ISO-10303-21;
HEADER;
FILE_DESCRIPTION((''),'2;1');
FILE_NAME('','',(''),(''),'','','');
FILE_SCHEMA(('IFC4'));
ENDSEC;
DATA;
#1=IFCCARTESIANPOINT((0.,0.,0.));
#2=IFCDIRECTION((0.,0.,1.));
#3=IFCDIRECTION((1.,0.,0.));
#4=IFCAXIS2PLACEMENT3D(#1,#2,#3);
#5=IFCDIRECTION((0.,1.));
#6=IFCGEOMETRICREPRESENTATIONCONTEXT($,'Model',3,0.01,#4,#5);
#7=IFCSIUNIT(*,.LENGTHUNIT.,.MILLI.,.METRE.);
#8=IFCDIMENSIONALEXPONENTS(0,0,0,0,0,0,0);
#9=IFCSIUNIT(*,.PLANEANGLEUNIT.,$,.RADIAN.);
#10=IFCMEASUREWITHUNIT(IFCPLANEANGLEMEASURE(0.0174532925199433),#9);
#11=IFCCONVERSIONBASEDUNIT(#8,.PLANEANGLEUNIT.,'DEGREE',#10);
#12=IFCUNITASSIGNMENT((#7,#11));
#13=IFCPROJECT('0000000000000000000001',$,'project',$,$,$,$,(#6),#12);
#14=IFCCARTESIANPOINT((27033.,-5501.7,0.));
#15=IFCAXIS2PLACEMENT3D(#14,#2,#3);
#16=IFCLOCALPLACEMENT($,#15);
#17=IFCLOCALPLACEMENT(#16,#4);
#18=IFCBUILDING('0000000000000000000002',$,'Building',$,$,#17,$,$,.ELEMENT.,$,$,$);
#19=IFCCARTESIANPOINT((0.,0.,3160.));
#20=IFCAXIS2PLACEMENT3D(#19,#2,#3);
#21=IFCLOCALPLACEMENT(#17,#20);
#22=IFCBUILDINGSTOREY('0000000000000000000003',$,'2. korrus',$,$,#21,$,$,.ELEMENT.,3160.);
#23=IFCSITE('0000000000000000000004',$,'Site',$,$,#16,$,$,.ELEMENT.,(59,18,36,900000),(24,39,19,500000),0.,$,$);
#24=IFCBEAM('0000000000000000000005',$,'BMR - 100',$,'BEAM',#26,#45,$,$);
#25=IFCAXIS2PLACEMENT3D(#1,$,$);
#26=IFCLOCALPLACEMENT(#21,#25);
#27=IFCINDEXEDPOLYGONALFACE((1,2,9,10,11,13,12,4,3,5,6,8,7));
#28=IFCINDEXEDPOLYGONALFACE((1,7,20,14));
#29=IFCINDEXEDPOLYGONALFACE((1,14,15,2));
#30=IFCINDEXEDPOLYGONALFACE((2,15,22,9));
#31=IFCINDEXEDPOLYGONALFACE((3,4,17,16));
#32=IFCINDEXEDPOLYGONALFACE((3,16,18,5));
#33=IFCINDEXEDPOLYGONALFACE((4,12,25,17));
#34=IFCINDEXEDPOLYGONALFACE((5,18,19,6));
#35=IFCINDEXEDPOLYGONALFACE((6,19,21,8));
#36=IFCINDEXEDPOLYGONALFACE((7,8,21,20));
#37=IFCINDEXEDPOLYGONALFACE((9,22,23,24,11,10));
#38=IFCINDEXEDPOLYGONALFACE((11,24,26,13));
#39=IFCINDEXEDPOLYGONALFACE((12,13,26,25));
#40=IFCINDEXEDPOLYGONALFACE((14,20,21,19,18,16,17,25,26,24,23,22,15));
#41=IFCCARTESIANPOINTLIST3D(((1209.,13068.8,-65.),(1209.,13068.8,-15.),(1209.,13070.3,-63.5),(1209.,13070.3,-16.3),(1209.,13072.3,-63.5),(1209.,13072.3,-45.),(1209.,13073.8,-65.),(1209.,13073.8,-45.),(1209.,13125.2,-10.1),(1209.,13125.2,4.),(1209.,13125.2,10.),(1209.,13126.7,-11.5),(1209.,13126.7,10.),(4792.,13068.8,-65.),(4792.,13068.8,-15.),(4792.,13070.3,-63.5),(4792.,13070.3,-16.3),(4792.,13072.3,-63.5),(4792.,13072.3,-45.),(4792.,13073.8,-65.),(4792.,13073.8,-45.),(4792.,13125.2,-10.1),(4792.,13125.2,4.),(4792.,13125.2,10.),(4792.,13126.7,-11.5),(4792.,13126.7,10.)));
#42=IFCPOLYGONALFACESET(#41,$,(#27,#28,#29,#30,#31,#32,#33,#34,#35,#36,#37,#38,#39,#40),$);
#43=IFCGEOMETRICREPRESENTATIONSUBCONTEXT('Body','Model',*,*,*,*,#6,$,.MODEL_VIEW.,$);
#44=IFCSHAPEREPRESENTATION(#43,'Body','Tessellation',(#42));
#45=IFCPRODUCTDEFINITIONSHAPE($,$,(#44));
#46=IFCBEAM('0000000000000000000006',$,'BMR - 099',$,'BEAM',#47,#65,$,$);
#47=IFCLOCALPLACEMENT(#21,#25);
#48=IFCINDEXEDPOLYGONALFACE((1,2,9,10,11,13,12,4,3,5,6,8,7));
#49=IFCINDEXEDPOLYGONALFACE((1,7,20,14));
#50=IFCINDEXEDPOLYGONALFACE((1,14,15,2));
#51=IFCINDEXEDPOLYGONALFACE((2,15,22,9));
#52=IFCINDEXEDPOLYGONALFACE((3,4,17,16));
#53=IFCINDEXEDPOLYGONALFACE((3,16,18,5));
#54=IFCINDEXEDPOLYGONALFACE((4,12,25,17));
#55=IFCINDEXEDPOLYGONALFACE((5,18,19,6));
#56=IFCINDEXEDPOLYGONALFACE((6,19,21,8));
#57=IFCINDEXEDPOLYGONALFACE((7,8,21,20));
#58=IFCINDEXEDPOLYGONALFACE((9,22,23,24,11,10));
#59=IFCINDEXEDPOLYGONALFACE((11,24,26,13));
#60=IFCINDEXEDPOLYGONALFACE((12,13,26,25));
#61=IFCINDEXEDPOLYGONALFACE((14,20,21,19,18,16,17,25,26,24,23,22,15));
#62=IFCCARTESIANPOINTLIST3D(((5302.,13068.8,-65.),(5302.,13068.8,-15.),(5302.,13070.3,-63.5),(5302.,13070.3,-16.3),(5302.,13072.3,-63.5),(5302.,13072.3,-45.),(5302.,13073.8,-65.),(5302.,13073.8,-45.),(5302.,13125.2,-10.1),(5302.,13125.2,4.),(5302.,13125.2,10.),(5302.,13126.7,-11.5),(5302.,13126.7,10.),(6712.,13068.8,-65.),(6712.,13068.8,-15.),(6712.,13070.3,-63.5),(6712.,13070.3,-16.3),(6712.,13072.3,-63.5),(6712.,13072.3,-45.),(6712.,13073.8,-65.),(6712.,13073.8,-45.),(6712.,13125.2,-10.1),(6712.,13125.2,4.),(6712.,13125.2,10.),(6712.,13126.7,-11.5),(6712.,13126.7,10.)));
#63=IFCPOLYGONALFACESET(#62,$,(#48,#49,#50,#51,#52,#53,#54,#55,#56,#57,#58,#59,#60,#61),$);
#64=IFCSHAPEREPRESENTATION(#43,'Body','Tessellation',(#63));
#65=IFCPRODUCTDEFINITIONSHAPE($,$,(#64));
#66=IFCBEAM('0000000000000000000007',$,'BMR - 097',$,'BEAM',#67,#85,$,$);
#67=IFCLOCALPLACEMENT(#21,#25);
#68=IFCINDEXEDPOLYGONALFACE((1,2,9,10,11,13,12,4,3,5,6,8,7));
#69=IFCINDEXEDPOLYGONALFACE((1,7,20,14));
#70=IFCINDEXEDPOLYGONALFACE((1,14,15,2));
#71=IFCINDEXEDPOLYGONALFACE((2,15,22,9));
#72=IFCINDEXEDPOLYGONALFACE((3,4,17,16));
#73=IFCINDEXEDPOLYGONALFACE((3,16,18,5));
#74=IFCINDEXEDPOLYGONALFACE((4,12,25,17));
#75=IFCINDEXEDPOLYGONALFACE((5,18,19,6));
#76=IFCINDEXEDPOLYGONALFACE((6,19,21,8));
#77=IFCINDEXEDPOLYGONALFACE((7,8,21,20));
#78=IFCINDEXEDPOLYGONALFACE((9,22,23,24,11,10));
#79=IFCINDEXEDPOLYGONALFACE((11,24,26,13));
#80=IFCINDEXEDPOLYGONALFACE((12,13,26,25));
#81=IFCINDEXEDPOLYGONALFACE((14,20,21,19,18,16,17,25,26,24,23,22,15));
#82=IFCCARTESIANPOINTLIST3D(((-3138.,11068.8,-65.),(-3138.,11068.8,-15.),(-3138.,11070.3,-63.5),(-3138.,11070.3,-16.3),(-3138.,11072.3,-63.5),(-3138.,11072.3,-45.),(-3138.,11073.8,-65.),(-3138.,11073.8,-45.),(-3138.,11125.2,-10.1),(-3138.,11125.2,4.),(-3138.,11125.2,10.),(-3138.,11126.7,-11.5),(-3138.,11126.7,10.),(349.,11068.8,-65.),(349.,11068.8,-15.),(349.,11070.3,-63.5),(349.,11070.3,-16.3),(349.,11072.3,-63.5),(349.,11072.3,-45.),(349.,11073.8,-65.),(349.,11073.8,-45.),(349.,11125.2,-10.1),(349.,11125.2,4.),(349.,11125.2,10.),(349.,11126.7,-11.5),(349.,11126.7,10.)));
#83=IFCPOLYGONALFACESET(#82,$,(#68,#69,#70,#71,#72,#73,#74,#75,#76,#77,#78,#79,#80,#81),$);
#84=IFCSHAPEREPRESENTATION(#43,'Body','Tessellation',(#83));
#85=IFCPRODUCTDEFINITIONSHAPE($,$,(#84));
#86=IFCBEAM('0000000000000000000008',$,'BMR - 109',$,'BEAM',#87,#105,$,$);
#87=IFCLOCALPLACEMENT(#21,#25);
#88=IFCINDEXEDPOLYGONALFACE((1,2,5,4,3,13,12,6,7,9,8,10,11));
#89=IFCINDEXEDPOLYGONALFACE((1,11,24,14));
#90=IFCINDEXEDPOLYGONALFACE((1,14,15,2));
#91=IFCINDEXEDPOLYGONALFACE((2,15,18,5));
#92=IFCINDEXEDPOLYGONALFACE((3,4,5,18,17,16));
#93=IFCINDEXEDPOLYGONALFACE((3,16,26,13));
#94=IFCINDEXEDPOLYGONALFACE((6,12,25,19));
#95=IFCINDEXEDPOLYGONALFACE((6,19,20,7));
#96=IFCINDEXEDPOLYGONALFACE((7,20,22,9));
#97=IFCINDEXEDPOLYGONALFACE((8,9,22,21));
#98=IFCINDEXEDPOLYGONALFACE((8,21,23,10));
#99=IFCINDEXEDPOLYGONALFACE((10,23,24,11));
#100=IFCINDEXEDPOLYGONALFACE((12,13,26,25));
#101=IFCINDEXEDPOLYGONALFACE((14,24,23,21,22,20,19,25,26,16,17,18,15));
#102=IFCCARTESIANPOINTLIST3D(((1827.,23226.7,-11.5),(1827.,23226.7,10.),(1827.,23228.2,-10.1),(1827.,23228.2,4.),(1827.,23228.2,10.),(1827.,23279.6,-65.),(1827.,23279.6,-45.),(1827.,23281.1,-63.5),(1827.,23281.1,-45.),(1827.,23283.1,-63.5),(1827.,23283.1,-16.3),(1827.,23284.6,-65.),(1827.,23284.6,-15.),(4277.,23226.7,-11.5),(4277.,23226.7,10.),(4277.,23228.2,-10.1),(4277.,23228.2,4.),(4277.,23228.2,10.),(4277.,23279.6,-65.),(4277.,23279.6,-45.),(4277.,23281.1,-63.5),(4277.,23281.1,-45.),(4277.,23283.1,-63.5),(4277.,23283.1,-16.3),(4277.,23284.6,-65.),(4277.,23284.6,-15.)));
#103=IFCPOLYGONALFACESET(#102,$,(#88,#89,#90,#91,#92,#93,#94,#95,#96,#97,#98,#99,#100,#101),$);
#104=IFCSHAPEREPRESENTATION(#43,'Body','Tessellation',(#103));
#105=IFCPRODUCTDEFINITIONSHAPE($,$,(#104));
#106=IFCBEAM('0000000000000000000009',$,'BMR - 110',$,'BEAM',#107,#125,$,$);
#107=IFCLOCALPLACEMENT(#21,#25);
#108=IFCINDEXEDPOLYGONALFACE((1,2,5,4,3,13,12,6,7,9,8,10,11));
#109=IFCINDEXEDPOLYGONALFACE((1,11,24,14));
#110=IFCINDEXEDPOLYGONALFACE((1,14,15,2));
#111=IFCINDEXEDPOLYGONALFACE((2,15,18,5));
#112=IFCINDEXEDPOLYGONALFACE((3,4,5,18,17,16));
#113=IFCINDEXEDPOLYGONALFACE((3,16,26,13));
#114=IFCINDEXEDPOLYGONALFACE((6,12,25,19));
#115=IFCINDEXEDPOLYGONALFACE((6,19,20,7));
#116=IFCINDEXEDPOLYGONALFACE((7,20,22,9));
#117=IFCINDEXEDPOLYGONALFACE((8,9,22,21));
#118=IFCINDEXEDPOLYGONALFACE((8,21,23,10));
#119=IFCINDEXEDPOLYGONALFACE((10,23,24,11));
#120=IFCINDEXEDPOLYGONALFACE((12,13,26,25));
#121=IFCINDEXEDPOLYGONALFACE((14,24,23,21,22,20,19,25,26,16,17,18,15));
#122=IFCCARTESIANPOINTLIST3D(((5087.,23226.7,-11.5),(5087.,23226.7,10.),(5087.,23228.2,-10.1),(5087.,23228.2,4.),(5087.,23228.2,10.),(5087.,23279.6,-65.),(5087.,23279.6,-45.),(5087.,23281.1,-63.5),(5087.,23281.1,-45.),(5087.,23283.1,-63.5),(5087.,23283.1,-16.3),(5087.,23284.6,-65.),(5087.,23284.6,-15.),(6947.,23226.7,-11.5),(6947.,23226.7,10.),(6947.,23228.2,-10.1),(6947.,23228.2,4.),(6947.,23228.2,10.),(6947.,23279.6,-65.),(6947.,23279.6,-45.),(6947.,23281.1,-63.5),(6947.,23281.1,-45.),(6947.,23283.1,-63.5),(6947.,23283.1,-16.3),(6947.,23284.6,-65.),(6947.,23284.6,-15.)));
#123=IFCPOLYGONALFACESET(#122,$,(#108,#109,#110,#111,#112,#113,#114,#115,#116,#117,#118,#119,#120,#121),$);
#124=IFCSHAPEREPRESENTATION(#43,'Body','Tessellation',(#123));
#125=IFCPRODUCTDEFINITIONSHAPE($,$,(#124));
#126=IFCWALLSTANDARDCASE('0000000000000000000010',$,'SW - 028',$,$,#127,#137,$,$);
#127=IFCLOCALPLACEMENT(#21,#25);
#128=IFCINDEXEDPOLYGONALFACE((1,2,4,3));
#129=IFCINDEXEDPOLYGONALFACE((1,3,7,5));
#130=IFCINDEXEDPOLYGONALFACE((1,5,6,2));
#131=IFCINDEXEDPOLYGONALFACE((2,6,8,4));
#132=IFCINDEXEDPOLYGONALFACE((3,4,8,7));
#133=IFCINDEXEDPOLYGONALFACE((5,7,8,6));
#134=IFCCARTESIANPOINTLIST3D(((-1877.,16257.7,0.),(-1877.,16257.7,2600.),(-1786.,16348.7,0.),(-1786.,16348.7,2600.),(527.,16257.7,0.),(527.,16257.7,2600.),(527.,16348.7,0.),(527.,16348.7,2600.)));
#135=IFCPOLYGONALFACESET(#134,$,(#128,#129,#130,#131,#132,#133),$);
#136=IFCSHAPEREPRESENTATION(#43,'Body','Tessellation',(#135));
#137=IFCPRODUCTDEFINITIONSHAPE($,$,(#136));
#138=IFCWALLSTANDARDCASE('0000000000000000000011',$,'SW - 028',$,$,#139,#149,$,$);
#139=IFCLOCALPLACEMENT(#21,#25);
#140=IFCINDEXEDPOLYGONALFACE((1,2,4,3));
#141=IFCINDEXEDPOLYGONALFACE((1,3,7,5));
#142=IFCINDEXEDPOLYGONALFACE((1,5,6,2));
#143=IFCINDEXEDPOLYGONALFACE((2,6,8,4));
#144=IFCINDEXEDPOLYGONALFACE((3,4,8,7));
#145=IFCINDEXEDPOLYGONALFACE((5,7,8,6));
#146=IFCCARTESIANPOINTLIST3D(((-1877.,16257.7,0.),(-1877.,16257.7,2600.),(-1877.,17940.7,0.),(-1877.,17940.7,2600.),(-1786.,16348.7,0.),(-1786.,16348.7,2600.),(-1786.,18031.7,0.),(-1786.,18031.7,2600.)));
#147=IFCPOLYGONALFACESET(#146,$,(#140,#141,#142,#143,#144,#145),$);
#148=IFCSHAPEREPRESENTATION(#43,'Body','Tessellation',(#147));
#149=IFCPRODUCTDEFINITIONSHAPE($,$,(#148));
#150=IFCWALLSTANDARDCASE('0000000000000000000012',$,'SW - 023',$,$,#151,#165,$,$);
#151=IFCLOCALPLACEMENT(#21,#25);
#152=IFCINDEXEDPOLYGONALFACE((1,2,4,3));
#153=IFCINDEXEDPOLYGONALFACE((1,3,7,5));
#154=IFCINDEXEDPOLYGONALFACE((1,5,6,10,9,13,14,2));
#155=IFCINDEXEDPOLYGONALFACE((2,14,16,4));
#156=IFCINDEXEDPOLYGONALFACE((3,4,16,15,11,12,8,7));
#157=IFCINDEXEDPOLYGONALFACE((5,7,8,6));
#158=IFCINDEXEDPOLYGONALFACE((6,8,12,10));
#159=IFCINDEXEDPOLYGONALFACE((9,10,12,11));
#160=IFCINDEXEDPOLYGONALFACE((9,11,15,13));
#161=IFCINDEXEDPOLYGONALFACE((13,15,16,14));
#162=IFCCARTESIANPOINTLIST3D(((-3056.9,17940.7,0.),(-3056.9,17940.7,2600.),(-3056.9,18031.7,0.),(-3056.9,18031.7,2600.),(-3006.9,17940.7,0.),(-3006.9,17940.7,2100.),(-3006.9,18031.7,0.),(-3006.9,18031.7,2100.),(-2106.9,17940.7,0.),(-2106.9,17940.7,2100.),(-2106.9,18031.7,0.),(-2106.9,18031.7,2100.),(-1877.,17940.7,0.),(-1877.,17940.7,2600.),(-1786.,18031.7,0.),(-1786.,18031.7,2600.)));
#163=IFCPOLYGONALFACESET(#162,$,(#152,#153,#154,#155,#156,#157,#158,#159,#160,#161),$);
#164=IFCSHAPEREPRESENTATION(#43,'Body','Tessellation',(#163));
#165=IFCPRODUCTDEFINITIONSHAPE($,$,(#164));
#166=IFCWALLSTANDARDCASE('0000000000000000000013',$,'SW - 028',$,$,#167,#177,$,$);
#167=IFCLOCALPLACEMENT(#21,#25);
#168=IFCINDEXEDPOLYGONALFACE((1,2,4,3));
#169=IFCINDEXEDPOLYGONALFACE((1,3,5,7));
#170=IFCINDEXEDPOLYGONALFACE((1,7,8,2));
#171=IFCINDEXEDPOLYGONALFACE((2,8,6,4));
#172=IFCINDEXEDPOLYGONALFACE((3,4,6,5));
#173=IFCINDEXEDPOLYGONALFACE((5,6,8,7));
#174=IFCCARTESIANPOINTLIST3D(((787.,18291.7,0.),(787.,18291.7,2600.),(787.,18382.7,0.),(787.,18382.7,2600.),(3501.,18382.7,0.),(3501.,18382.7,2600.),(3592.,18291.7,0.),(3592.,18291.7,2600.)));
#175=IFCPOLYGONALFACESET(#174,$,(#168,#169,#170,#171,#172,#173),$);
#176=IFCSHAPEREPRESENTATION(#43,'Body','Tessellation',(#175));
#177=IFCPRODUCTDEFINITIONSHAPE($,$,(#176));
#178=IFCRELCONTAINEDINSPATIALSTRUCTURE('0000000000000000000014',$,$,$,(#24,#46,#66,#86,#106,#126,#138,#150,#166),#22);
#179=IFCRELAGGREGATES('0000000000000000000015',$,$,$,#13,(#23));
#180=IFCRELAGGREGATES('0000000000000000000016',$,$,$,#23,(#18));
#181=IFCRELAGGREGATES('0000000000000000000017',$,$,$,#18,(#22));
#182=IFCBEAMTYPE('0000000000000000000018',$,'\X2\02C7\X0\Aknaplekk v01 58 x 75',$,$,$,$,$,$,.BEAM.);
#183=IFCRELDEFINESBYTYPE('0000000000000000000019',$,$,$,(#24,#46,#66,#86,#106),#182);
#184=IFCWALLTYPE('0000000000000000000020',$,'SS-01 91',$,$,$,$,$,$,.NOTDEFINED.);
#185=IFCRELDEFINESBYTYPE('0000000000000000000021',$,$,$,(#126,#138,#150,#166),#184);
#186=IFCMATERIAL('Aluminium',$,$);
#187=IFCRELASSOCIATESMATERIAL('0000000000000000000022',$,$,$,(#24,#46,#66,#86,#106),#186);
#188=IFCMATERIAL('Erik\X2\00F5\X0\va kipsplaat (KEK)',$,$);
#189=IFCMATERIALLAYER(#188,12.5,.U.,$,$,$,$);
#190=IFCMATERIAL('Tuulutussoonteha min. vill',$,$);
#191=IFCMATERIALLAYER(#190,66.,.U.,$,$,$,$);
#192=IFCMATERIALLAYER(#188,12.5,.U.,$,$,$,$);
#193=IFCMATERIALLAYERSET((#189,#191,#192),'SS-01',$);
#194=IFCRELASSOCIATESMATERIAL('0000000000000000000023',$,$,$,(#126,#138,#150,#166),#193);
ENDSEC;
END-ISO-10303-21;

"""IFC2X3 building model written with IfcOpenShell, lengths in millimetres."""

from ifc_helpers import new_model, entity, si_unit, converted_unit, direction, frame, origin_with_axes, origin_2d_with_axis, place, context, subcontext, project, spatial, polyline, rectangle, outline, extrude, material, layer, layer_set, layer_usage, type_object, element, save


model = new_model("IFC2X3")

# Units and contexts
model_context = context("Model", 3, precision=0.01, world=origin_with_axes(), true_north=direction((0.0, 1.0)))
body_context = subcontext(model_context, "Body", "Model", "MODEL_VIEW")
ifc_project = project(units=[si_unit("LENGTHUNIT", "METRE", prefix="MILLI"), converted_unit("PLANEANGLEUNIT", "DEGREE", entity("IfcPlaneAngleMeasure", 0.0174532925199433), si_unit("PLANEANGLEUNIT", "RADIAN"), dimensions=[0, 0, 0, 0, 0, 0, 0])], contexts=[model_context])

# Site, building, storey
site_placement = place(None, frame((27033.0, -5501.7, 0.0), z_axis=(0.0, 0.0, 1.0), x_axis=(1.0, 0.0, 0.0)))
site = spatial("IfcSite", under=ifc_project, at=site_placement, Name="Site", CompositionType="ELEMENT", RefLatitude=(59, 18, 36, 900000), RefLongitude=(24, 39, 19, 500000), RefElevation=0.0)
building_placement = place(site_placement, origin_with_axes())
building = spatial("IfcBuilding", under=site, at=building_placement, Name="Building", CompositionType="ELEMENT")
storey_placement = place(building_placement, frame((0.0, 0.0, 3160.0), z_axis=(0.0, 0.0, 1.0), x_axis=(1.0, 0.0, 0.0)))
storey = spatial("IfcBuildingStorey", under=building, at=storey_placement, Name="2. korrus", CompositionType="ELEMENT", Elevation=3160.0)

# Beams
ifc_material_1 = material(Name="Aluminium")
beam_type = type_object("IfcBeamType", Name="ˇAknaplekk v01 58 x 75", PredefinedType="BEAM")
beam_1_placement = place(storey_placement, frame((4792.0, 13126.7, 0.0), z_axis=(0.0, 0.0, 1.0), x_axis=(0.0, 1.0, 0.0)))
element("IfcBeam", 1, at=beam_1_placement, inside=storey, type_object=beam_type, material=ifc_material_1, Name="BMR - 100", ObjectType="BEAM", context=body_context, shape_type="SweptSolid", body=[
    extrude(outline(polyline([(-57.9, -15.0), (-57.9, -65.0), (-52.9, -65.0), (-52.9, -45.0), (-54.4, -45.0), (-54.4, -63.5), (-56.4, -63.5), (-56.4, -16.3), (0.0, -11.5), (0.0, 10.0), (-1.5, 10.0), (-1.5, 4.0), (-1.5, -10.1), (-57.9, -15.0)])), frame((0.0, 3583.0, 0.0), z_axis=(0.0, -1.0, 0.0), x_axis=(1.0, 0.0, 0.0)), (0.0, 0.0, 1.0), 3583.0),
])
beam_2_placement = place(storey_placement, frame((6712.0, 13126.7, 0.0), z_axis=(0.0, 0.0, 1.0), x_axis=(0.000001, 1.0, 0.0)))
element("IfcBeam", 2, at=beam_2_placement, inside=storey, type_object=beam_type, material=ifc_material_1, Name="BMR - 099", ObjectType="BEAM", context=body_context, shape_type="SweptSolid", body=[
    extrude(outline(polyline([(-57.9, -15.0), (-57.9, -65.0), (-52.9, -65.0), (-52.9, -45.0), (-54.4, -45.0), (-54.4, -63.5), (-56.4, -63.5), (-56.4, -16.3), (0.0, -11.5), (0.0, 10.0), (-1.5, 10.0), (-1.5, 4.0), (-1.5, -10.1), (-57.9, -15.0)])), frame((0.0, 1410.0, 0.0), z_axis=(0.0, -1.0, 0.0), x_axis=(1.0, 0.0, 0.0)), (0.0, 0.0, 1.0), 1410.0),
])
beam_3_placement = place(storey_placement, frame((349.0, 11126.7, 0.0), z_axis=(0.0, 0.0, 1.0), x_axis=(0.0, 1.0, 0.0)))
element("IfcBeam", 3, at=beam_3_placement, inside=storey, type_object=beam_type, material=ifc_material_1, Name="BMR - 097", ObjectType="BEAM", context=body_context, shape_type="SweptSolid", body=[
    extrude(outline(polyline([(-57.9, -15.0), (-57.9, -65.0), (-52.9, -65.0), (-52.9, -45.0), (-54.4, -45.0), (-54.4, -63.5), (-56.4, -63.5), (-56.4, -16.3), (0.0, -11.5), (0.0, 10.0), (-1.5, 10.0), (-1.5, 4.0), (-1.5, -10.1), (-57.9, -15.0)])), frame((0.0, 3486.9, 0.0), z_axis=(0.0, -1.0, 0.0), x_axis=(1.0, 0.0, 0.0)), (0.0, 0.0, 1.0), 3486.9),
])
beam_4_placement = place(storey_placement, frame((1827.0, 23226.7, 0.0), z_axis=(0.0, 0.0, 1.0), x_axis=(-0.000004, -1.0, 0.0)))
element("IfcBeam", 4, at=beam_4_placement, inside=storey, type_object=beam_type, material=ifc_material_1, Name="BMR - 109", ObjectType="BEAM", context=body_context, shape_type="SweptSolid", body=[
    extrude(outline(polyline([(-57.9, -15.0), (-57.9, -65.0), (-52.9, -65.0), (-52.9, -45.0), (-54.4, -45.0), (-54.4, -63.5), (-56.4, -63.5), (-56.4, -16.3), (0.0, -11.5), (0.0, 10.0), (-1.5, 10.0), (-1.5, 4.0), (-1.5, -10.1), (-57.9, -15.0)])), frame((0.0, 2450.0, 0.0), z_axis=(0.0, -1.0, 0.0), x_axis=(1.0, 0.0, 0.0)), (0.0, 0.0, 1.0), 2450.0),
])
beam_5_placement = place(storey_placement, frame((5087.0, 23226.7, 0.0), z_axis=(0.0, 0.0, 1.0), x_axis=(0.0, -1.0, 0.0)))
element("IfcBeam", 5, at=beam_5_placement, inside=storey, type_object=beam_type, material=ifc_material_1, Name="BMR - 110", ObjectType="BEAM", context=body_context, shape_type="SweptSolid", body=[
    extrude(outline(polyline([(-57.9, -15.0), (-57.9, -65.0), (-52.9, -65.0), (-52.9, -45.0), (-54.4, -45.0), (-54.4, -63.5), (-56.4, -63.5), (-56.4, -16.3), (0.0, -11.5), (0.0, 10.0), (-1.5, 10.0), (-1.5, 4.0), (-1.5, -10.1), (-57.9, -15.0)])), frame((0.0, 1860.0, 0.0), z_axis=(0.0, -1.0, 0.0), x_axis=(1.0, 0.0, 0.0)), (0.0, 0.0, 1.0), 1860.0),
])

# Walls
ifc_material_2 = material(Name="Erikõva kipsplaat (KEK)")
ifc_layer_1 = layer(ifc_material_2, 12.5, ventilated="UNKNOWN")
ifc_material_3 = material(Name="Tuulutussoonteha min. vill")
ifc_layer_2 = layer(ifc_material_3, 66.0, ventilated="UNKNOWN")
ifc_layer_3 = layer(ifc_material_2, 12.5, ventilated="UNKNOWN")
ifc_layer_set_1 = layer_set([ifc_layer_1, ifc_layer_2, ifc_layer_3], Name="SS-01")
ifc_layer_usage_1 = layer_usage(ifc_layer_set_1, "AXIS2", "POSITIVE", -91.0)
wall_type_1 = type_object("IfcWallType", Name="SS-01 91", PredefinedType="NOTDEFINED")
wall_1_placement = place(storey_placement, frame((527.0, 16257.7, 0.0), z_axis=(0.0, 0.0, 1.0), x_axis=(-1.0, 0.0, 0.0)))
element("IfcWallStandardCase", 6, at=wall_1_placement, inside=storey, type_object=wall_type_1, material=ifc_layer_usage_1, Name="SW - 028", context=body_context, shape_type="SweptSolid", body=[
    extrude(outline(polyline([(0.0, -91.0), (2313.0, -91.0), (2404.0, 0.0), (0.0, 0.0), (0.0, -91.0)])), origin_with_axes(), (0.0, 0.0, 1.0), 2600.0),
])
ifc_layer_usage_2 = layer_usage(ifc_layer_set_1, "AXIS2", "POSITIVE", -91.0)
wall_2_placement = place(storey_placement, frame((-1877.0, 16257.7, 0.0), z_axis=(0.0, 0.0, 1.0), x_axis=(0.0, 1.0, 0.0)))
element("IfcWallStandardCase", 7, at=wall_2_placement, inside=storey, type_object=wall_type_1, material=ifc_layer_usage_2, Name="SW - 028", context=body_context, shape_type="SweptSolid", body=[
    extrude(outline(polyline([(91.0, -91.0), (1774.0, -91.0), (1683.0, 0.0), (0.0, 0.0), (91.0, -91.0)])), origin_with_axes(), (0.0, 0.0, 1.0), 2600.0),
])

# Wall, opening
ifc_layer_usage_3 = layer_usage(ifc_layer_set_1, "AXIS2", "POSITIVE", -91.0)
wall_3_placement = place(storey_placement, frame((-1877.0, 17940.7, 0.0), z_axis=(0.0, 0.0, 1.0), x_axis=(-1.0, 0.0, 0.0)))
wall_3 = element("IfcWallStandardCase", 8, at=wall_3_placement, inside=storey, type_object=wall_type_1, material=ifc_layer_usage_3, Name="SW - 023", context=body_context, shape_type="SweptSolid", body=[
    extrude(outline(polyline([(-91.0, -91.0), (1180.0, -91.0), (1180.0, 0.0), (0.0, 0.0), (-91.0, -91.0)])), origin_with_axes(), (0.0, 0.0, 1.0), 2600.0),
])
opening_1_placement = place(wall_3_placement, frame((679.9, 0.0, 0.0), z_axis=(0.0, 0.0, 1.0), x_axis=(1.0, 0.0, 0.0)))
element("IfcOpeningElement", 9, at=opening_1_placement, cuts=wall_3, context=body_context, shape_type="SweptSolid", body=[
    extrude(rectangle(XDim=900.0, YDim=2100.0, at=origin_2d_with_axis()), frame((0.0, 91.0, 1050.0), z_axis=(0.0, 1.0, 0.0), x_axis=(1.0, 0.0, 0.0)), (0.0, 0.0, -1.0), 273.0),
    extrude(rectangle(XDim=974.0, YDim=2137.0, at=origin_2d_with_axis()), frame((0.0, -91.0, 1068.5), z_axis=(0.0, -1.0, 0.0), x_axis=(1.0, 0.0, 0.0)), (0.0, 0.0, 1.0), 91.0),
])

# Wall
ifc_layer_usage_4 = layer_usage(ifc_layer_set_1, "AXIS2", "NEGATIVE", 91.0)
wall_4_placement = place(storey_placement, frame((787.0, 18291.7, 0.0), z_axis=(0.0, 0.0, 1.0), x_axis=(1.0, 0.0, 0.0)))
element("IfcWallStandardCase", 10, at=wall_4_placement, inside=storey, type_object=wall_type_1, material=ifc_layer_usage_4, Name="SW - 028", context=body_context, shape_type="SweptSolid", body=[
    extrude(outline(polyline([(0.0, 0.0), (2805.0, 0.0), (2714.0, 91.0), (0.0, 91.0), (0.0, 0.0)])), origin_with_axes(), (0.0, 0.0, 1.0), 2600.0),
])

save(model, "model.ifc")
